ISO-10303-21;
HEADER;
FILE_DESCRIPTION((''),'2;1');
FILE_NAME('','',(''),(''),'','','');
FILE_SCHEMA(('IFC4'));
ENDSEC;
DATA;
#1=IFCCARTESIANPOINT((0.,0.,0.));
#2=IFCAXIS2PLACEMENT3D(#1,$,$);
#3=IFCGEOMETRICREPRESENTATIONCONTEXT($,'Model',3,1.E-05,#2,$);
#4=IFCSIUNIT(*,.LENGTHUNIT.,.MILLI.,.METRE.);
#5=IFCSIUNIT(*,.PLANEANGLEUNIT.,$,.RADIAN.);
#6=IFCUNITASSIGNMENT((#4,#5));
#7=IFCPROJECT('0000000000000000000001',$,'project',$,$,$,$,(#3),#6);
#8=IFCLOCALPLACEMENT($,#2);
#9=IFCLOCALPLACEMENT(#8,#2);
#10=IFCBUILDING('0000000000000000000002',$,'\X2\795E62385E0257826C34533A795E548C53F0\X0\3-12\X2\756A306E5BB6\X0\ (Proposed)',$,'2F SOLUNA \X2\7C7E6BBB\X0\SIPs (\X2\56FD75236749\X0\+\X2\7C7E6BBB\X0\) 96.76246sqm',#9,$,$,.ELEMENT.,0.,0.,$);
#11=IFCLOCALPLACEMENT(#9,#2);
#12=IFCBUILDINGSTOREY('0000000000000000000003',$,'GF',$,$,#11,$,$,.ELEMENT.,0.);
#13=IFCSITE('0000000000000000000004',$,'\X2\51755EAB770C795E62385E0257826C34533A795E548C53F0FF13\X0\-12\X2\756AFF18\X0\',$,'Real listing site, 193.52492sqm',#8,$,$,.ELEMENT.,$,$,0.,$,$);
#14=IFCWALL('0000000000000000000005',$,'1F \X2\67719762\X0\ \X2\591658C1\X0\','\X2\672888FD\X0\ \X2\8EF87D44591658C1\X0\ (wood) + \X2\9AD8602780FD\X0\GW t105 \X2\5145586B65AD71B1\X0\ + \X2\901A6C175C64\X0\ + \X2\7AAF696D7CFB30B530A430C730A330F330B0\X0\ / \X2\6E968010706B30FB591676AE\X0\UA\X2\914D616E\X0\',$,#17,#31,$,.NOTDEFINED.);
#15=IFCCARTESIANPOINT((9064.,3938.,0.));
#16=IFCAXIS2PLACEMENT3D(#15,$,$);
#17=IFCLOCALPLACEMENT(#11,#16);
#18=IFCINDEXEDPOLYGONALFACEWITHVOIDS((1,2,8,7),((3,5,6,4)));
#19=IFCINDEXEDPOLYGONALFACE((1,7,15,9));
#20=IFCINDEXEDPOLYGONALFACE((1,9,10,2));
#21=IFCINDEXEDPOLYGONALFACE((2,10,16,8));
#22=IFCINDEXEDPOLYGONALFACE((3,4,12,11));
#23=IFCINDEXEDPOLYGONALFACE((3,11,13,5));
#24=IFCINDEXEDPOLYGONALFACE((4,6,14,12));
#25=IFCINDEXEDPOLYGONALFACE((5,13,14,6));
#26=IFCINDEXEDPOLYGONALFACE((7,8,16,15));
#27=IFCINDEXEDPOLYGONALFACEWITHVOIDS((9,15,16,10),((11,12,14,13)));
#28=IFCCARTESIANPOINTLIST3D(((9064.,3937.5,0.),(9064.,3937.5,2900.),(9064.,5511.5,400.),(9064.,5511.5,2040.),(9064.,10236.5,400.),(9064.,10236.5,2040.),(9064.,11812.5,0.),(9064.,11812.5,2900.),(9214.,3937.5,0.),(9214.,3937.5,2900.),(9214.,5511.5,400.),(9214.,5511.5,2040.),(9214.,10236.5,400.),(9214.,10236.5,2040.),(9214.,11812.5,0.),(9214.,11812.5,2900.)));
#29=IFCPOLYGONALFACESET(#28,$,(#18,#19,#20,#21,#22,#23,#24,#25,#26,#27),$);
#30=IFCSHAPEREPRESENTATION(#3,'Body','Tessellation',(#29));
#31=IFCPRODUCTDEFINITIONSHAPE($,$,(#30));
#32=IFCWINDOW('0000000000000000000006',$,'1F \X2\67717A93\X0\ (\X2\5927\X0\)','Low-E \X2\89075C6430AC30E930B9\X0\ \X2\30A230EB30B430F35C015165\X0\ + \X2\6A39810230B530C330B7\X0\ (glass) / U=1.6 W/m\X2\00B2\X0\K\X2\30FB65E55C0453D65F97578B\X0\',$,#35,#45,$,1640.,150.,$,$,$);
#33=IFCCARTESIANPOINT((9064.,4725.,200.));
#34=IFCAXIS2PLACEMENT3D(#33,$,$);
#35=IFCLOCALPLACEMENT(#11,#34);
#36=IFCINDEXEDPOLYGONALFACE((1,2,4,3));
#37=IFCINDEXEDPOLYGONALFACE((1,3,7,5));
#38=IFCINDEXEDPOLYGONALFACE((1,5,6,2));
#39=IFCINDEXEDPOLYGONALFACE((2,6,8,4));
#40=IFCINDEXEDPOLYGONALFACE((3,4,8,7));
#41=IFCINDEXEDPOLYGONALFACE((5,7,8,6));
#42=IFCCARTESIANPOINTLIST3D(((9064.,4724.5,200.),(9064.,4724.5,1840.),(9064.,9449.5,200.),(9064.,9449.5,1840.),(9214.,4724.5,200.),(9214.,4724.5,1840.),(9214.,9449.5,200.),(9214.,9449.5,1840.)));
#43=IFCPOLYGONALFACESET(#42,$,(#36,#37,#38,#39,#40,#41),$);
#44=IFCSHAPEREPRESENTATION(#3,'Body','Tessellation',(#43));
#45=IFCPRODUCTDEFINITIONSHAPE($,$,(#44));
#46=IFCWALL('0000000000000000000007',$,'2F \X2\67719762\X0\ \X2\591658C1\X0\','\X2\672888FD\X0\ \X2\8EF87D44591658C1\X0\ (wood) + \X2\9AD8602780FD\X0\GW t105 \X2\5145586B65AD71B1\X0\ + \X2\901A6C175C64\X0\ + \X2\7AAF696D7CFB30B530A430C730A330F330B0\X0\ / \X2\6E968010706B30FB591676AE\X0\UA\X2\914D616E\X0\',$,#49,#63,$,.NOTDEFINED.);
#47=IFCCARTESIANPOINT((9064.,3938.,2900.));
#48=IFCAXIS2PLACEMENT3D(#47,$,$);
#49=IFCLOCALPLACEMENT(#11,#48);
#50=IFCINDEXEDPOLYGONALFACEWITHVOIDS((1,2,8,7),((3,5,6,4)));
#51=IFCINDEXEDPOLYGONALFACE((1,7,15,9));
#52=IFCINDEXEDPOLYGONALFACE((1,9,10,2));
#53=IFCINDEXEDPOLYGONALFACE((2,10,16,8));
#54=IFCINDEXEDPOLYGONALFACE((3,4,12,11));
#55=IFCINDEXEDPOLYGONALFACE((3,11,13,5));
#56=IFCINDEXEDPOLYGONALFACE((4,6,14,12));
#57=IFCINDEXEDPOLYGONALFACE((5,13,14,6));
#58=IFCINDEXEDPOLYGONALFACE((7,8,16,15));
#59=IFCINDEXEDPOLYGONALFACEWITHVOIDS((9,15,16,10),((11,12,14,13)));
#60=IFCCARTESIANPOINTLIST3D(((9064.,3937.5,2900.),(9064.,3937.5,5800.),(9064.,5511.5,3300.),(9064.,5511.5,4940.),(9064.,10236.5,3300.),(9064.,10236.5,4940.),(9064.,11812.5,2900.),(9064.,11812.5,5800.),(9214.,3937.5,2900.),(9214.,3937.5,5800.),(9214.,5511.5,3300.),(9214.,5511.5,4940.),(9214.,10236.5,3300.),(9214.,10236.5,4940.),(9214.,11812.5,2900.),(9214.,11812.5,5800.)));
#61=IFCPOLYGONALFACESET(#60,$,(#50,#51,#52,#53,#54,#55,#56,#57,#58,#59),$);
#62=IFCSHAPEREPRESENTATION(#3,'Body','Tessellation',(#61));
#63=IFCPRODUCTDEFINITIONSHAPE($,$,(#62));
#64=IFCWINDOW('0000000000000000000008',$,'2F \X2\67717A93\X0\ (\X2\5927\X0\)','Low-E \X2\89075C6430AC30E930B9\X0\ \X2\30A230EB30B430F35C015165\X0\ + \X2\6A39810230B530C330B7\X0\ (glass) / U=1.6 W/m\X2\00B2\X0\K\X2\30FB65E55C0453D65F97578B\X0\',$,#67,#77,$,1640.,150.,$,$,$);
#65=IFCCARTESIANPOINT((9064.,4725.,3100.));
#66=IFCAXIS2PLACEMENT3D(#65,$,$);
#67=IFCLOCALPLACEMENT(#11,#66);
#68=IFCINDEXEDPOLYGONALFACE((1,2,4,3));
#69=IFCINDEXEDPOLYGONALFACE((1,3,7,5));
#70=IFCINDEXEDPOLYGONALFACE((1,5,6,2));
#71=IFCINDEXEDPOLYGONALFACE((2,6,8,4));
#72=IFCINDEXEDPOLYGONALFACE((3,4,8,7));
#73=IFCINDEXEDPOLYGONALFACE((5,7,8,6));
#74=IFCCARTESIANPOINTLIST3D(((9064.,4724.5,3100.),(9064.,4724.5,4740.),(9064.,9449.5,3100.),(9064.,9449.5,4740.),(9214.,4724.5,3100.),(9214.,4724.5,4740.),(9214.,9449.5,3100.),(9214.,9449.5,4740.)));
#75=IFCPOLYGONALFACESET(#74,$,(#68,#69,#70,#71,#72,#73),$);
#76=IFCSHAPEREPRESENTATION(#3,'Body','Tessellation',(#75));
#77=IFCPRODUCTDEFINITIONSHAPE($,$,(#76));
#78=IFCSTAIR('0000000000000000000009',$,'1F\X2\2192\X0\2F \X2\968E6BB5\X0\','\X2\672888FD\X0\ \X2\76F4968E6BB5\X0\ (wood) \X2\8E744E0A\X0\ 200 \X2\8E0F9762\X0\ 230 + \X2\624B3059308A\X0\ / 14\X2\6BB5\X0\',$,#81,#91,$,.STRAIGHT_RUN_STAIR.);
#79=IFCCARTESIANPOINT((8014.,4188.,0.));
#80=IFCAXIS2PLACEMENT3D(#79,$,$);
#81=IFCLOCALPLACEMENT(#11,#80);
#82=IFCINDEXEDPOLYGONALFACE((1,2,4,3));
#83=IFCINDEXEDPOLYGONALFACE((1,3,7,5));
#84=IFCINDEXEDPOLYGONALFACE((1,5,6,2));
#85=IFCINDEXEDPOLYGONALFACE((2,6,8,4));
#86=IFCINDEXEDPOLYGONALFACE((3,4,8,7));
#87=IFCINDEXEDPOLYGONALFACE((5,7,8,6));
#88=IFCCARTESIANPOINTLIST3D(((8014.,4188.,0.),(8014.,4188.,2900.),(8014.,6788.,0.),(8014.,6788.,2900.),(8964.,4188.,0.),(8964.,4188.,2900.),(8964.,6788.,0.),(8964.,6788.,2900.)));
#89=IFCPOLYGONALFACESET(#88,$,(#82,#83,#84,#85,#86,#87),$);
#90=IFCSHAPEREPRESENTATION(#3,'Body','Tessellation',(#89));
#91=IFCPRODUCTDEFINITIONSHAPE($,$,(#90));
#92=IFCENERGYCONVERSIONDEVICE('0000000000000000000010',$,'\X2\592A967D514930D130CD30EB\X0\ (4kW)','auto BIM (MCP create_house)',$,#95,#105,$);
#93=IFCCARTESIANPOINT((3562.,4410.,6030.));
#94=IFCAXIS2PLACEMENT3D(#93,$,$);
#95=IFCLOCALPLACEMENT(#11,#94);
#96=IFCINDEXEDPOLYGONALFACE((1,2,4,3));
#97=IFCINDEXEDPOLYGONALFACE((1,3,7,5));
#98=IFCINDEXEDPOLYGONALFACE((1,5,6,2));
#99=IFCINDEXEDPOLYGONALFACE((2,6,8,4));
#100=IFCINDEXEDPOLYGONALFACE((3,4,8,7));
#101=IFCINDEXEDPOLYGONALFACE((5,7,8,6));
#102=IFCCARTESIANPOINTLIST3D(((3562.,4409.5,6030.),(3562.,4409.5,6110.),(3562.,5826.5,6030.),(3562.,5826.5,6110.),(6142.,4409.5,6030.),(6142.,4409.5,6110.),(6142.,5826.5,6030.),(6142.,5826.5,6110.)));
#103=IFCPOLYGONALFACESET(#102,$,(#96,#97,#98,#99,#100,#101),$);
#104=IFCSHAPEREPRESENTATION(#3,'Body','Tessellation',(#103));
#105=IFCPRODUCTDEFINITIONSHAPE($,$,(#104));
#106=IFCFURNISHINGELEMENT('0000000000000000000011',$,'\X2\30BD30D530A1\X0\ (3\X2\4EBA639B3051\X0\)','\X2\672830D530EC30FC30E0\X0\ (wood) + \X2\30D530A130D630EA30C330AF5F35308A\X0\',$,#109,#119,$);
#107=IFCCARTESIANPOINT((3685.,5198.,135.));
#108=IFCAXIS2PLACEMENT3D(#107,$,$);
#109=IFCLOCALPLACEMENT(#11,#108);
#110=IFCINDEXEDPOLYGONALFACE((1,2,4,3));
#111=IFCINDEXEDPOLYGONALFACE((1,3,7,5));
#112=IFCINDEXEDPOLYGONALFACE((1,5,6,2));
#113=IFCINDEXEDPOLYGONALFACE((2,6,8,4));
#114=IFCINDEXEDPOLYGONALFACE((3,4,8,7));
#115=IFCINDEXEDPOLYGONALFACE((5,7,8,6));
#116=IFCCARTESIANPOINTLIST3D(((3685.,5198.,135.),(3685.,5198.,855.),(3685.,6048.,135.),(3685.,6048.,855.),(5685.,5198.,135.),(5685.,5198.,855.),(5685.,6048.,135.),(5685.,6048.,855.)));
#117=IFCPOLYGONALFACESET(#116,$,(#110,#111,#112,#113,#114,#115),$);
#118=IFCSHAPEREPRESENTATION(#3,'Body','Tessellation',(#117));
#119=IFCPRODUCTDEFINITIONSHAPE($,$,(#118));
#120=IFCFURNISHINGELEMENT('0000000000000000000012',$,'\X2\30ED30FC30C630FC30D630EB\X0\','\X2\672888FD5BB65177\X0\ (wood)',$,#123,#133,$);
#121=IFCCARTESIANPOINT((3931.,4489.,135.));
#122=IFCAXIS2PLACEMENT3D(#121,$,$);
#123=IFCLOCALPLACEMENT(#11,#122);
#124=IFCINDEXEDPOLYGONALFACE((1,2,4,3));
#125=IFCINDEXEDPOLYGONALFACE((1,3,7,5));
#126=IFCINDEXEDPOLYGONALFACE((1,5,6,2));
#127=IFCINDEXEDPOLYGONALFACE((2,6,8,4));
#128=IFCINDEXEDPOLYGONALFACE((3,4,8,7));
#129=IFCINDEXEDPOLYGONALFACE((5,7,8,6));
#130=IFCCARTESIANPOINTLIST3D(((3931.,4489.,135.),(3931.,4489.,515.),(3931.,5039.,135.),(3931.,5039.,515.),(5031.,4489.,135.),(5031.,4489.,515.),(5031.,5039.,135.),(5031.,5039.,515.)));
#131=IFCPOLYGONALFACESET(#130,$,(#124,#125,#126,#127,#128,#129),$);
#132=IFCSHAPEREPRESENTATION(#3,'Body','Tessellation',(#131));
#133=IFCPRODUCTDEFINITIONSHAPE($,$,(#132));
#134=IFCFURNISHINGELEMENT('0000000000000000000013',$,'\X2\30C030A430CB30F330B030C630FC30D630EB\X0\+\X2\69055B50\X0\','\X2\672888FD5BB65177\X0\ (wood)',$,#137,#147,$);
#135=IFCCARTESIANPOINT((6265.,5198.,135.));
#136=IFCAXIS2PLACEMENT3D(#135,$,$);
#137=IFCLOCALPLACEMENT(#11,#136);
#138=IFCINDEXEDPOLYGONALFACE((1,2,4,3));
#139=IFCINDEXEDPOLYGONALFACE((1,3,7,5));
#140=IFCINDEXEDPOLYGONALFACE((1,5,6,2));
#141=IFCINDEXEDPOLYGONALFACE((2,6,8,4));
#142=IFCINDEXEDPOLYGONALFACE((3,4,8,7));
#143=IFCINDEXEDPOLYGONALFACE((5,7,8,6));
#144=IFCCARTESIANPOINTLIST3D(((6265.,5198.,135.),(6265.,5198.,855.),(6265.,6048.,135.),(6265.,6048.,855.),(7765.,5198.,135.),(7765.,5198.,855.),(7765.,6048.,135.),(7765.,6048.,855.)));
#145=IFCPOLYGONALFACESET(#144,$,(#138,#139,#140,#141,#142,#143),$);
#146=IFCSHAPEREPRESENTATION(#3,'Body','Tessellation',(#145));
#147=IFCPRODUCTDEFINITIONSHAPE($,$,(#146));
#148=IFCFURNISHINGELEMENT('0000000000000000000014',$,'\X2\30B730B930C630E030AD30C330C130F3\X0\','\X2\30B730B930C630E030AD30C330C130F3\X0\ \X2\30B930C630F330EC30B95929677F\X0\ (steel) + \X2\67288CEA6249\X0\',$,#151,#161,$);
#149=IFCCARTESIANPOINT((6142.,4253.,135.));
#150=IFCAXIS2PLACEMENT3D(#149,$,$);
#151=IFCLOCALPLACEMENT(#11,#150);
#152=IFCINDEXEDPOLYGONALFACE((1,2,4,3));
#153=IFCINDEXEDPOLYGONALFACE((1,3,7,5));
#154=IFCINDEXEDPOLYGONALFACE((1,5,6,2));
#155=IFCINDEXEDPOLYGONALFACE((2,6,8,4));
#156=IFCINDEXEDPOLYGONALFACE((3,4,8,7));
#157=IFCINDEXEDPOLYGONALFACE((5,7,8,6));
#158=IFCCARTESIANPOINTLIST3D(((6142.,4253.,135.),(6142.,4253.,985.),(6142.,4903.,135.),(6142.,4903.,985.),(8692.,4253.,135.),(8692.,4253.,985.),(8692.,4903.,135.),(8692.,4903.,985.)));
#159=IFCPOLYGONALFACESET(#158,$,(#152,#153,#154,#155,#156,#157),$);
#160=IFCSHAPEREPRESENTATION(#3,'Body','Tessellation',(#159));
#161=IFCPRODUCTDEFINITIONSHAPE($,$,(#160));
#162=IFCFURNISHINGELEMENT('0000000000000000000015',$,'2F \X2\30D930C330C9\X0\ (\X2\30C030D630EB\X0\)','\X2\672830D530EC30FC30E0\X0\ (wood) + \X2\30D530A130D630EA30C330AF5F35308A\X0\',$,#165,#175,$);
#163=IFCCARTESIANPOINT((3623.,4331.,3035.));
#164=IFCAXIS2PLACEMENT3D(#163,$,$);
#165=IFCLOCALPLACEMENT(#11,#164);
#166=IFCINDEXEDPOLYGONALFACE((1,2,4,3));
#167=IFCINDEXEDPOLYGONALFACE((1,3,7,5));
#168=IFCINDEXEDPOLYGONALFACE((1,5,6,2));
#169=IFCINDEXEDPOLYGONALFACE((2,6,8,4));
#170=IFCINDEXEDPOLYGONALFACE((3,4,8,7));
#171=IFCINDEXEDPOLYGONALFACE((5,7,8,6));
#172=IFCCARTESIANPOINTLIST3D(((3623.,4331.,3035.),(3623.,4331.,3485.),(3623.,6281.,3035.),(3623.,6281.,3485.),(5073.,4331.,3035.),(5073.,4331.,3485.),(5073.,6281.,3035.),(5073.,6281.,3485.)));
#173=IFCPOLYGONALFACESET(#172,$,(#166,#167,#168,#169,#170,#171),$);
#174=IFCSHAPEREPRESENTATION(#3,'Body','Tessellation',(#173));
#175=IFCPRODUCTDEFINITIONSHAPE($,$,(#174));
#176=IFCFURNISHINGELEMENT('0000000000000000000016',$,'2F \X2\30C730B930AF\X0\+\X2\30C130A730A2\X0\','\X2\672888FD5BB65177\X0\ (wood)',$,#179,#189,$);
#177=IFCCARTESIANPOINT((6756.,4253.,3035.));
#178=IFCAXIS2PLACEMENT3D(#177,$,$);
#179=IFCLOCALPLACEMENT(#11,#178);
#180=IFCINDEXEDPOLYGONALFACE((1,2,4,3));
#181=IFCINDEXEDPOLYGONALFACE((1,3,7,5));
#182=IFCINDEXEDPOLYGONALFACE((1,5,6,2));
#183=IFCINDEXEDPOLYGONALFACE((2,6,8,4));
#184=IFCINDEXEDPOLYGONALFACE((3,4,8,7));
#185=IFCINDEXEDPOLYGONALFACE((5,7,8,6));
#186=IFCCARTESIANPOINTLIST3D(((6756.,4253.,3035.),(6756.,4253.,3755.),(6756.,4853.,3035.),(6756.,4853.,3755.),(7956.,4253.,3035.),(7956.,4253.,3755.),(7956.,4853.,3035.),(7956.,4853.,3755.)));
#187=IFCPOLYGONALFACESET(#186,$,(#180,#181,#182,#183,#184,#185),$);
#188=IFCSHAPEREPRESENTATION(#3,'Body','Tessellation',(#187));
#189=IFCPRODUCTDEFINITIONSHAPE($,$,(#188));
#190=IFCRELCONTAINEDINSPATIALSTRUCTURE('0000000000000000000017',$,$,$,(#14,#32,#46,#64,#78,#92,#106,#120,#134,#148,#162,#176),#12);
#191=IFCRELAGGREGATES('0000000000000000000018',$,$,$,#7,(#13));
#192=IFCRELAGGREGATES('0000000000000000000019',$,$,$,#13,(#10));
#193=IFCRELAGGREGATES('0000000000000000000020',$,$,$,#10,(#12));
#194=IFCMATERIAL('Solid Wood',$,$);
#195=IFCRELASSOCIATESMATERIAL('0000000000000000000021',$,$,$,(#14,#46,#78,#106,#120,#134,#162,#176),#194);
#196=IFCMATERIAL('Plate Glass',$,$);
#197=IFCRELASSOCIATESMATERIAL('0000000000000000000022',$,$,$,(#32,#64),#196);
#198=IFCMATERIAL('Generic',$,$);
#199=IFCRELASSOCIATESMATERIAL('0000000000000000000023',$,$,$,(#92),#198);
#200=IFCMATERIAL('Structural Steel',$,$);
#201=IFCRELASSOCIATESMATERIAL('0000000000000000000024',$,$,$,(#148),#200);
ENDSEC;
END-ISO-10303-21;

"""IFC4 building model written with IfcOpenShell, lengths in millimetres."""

from ifc_helpers import new_model, si_unit, frame, frame_2d, origin, place, context, project, spatial, rectangle, extrude, material, element, fill, save


model = new_model("IFC4")

# Units and contexts
model_context = context("Model", 3, precision=1e-05, world=origin())
ifc_project = project(units=[si_unit("LENGTHUNIT", "METRE", prefix="MILLI"), si_unit("PLANEANGLEUNIT", "RADIAN")], contexts=[model_context])

# Site, building, storey
site_placement = place(None, origin())
site = spatial("IfcSite", under=ifc_project, at=site_placement, Name="兵庫県神戸市垂水区神和台３-12番８", ObjectType="Real listing site, 193.52492sqm", CompositionType="ELEMENT", RefElevation=0.0)
building_placement = place(site_placement, origin())
building = spatial("IfcBuilding", under=site, at=building_placement, Name="神戸市垂水区神和台3-12番の家 (Proposed)", ObjectType="2F SOLUNA 籾殻SIPs (国産杉+籾殻) 96.76246sqm", CompositionType="ELEMENT", ElevationOfRefHeight=0.0, ElevationOfTerrain=0.0)
storey_placement = place(building_placement, origin())
storey = spatial("IfcBuildingStorey", under=building, at=storey_placement, Name="GF", CompositionType="ELEMENT", Elevation=0.0)

# Wall, opening, window
ifc_material_1 = material(Name="Solid Wood")
wall_1_placement = place(storey_placement, frame((9064.0, 3938.0, 0.0)))
wall_1 = element("IfcWall", 1, at=wall_1_placement, inside=storey, material=ifc_material_1, Name="1F 東面 外壁", Description="木製 軸組外壁 (wood) + 高性能GW t105 充填断熱 + 通気層 + 窯業系サイディング / 準耐火・外皮UA配慮", PredefinedType="NOTDEFINED", context=model_context, shape_type="SweptSolid", body=[
    extrude(rectangle(XDim=150.0, YDim=7875.0, at=frame_2d((75.0, 3937.0))), frame((9064.0, 3938.0, 0.0)), (0.0, 0.0, 1.0), 2900.0),
])
opening_1_placement = place(storey_placement, frame((9064.0, 4725.0, 200.0)))
opening_1 = element("IfcOpeningElement", 2, at=opening_1_placement, cuts=wall_1, PredefinedType="NOTDEFINED", context=model_context, shape_type="SweptSolid", body=[
    extrude(rectangle(XDim=150.0, YDim=4725.0, at=frame_2d((75.0, 2362.0))), frame((9064.0, 4725.0, 200.0)), (0.0, 0.0, 1.0), 1640.0),
])
ifc_material_2 = material(Name="Plate Glass")
window_1_placement = place(storey_placement, frame((9064.0, 4725.0, 200.0)))
window_1 = element("IfcWindow", 3, at=window_1_placement, inside=storey, material=ifc_material_2, Name="1F 東窓 (大)", Description="Low-E 複層ガラス アルゴン封入 + 樹脂サッシ (glass) / U=1.6 W/m²K・日射取得型", OverallHeight=1640.0, OverallWidth=150.0, context=model_context, shape_type="SweptSolid", body=[
    extrude(rectangle(XDim=150.0, YDim=4725.0, at=frame_2d((75.0, 2362.0))), frame((9064.0, 4725.0, 200.0)), (0.0, 0.0, 1.0), 1640.0),
])
fill(opening_1, window_1)

# Wall, opening, window
wall_2_placement = place(storey_placement, frame((9064.0, 3938.0, 2900.0)))
wall_2 = element("IfcWall", 4, at=wall_2_placement, inside=storey, material=ifc_material_1, Name="2F 東面 外壁", Description="木製 軸組外壁 (wood) + 高性能GW t105 充填断熱 + 通気層 + 窯業系サイディング / 準耐火・外皮UA配慮", PredefinedType="NOTDEFINED", context=model_context, shape_type="SweptSolid", body=[
    extrude(rectangle(XDim=150.0, YDim=7875.0, at=frame_2d((75.0, 3937.0))), frame((9064.0, 3938.0, 2900.0)), (0.0, 0.0, 1.0), 2900.0),
])
opening_2_placement = place(storey_placement, frame((9064.0, 4725.0, 3100.0)))
opening_2 = element("IfcOpeningElement", 5, at=opening_2_placement, cuts=wall_2, PredefinedType="NOTDEFINED", context=model_context, shape_type="SweptSolid", body=[
    extrude(rectangle(XDim=150.0, YDim=4725.0, at=frame_2d((75.0, 2362.0))), frame((9064.0, 4725.0, 3100.0)), (0.0, 0.0, 1.0), 1640.0),
])
window_2_placement = place(storey_placement, frame((9064.0, 4725.0, 3100.0)))
window_2 = element("IfcWindow", 6, at=window_2_placement, inside=storey, material=ifc_material_2, Name="2F 東窓 (大)", Description="Low-E 複層ガラス アルゴン封入 + 樹脂サッシ (glass) / U=1.6 W/m²K・日射取得型", OverallHeight=1640.0, OverallWidth=150.0, context=model_context, shape_type="SweptSolid", body=[
    extrude(rectangle(XDim=150.0, YDim=4725.0, at=frame_2d((75.0, 2362.0))), frame((9064.0, 4725.0, 3100.0)), (0.0, 0.0, 1.0), 1640.0),
])
fill(opening_2, window_2)

# Stair
stair_placement = place(storey_placement, frame((8014.0, 4188.0, 0.0)))
element("IfcStair", 7, at=stair_placement, inside=storey, material=ifc_material_1, Name="1F→2F 階段", Description="木製 直階段 (wood) 蹴上 200 踏面 230 + 手すり / 14段", PredefinedType="STRAIGHT_RUN_STAIR", context=model_context, shape_type="SweptSolid", body=[
    extrude(rectangle(XDim=950.0, YDim=2600.0, at=frame_2d((475.0, 1300.0))), frame((8014.0, 4188.0, 0.0)), (0.0, 0.0, 1.0), 2900.0),
])

# Energy conversion device
ifc_material_3 = material(Name="Generic")
energy_conversion_device_placement = place(storey_placement, frame((3562.0, 4410.0, 6030.0)))
element("IfcEnergyConversionDevice", 8, at=energy_conversion_device_placement, inside=storey, material=ifc_material_3, Name="太陽光パネル (4kW)", Description="auto BIM (MCP create_house)", context=model_context, shape_type="SweptSolid", body=[
    extrude(rectangle(XDim=2580.0, YDim=1417.0, at=frame_2d((1290.0, 708.0))), frame((3562.0, 4410.0, 6030.0)), (0.0, 0.0, 1.0), 80.0),
])

# Furnishing elements
furnishing_1_placement = place(storey_placement, frame((3685.0, 5198.0, 135.0)))
element("IfcFurnishingElement", 9, at=furnishing_1_placement, inside=storey, material=ifc_material_1, Name="ソファ (3人掛け)", Description="木フレーム (wood) + ファブリック張り", context=model_context, shape_type="SweptSolid", body=[
    extrude(rectangle(XDim=2000.0, YDim=850.0, at=frame_2d((1000.0, 425.0))), frame((3685.0, 5198.0, 135.0)), (0.0, 0.0, 1.0), 720.0),
])
furnishing_2_placement = place(storey_placement, frame((3931.0, 4489.0, 135.0)))
element("IfcFurnishingElement", 10, at=furnishing_2_placement, inside=storey, material=ifc_material_1, Name="ローテーブル", Description="木製家具 (wood)", context=model_context, shape_type="SweptSolid", body=[
    extrude(rectangle(XDim=1100.0, YDim=550.0, at=frame_2d((550.0, 275.0))), frame((3931.0, 4489.0, 135.0)), (0.0, 0.0, 1.0), 380.0),
])
furnishing_3_placement = place(storey_placement, frame((6265.0, 5198.0, 135.0)))
element("IfcFurnishingElement", 11, at=furnishing_3_placement, inside=storey, material=ifc_material_1, Name="ダイニングテーブル+椅子", Description="木製家具 (wood)", context=model_context, shape_type="SweptSolid", body=[
    extrude(rectangle(XDim=1500.0, YDim=850.0, at=frame_2d((750.0, 425.0))), frame((6265.0, 5198.0, 135.0)), (0.0, 0.0, 1.0), 720.0),
])
ifc_material_4 = material(Name="Structural Steel")
furnishing_4_placement = place(storey_placement, frame((6142.0, 4253.0, 135.0)))
element("IfcFurnishingElement", 12, at=furnishing_4_placement, inside=storey, material=ifc_material_4, Name="システムキッチン", Description="システムキッチン ステンレス天板 (steel) + 木質扉", context=model_context, shape_type="SweptSolid", body=[
    extrude(rectangle(XDim=2550.0, YDim=650.0, at=frame_2d((1275.0, 325.0))), frame((6142.0, 4253.0, 135.0)), (0.0, 0.0, 1.0), 850.0),
])
furnishing_5_placement = place(storey_placement, frame((3623.0, 4331.0, 3035.0)))
element("IfcFurnishingElement", 13, at=furnishing_5_placement, inside=storey, material=ifc_material_1, Name="2F ベッド (ダブル)", Description="木フレーム (wood) + ファブリック張り", context=model_context, shape_type="SweptSolid", body=[
    extrude(rectangle(XDim=1450.0, YDim=1950.0, at=frame_2d((725.0, 975.0))), frame((3623.0, 4331.0, 3035.0)), (0.0, 0.0, 1.0), 450.0),
])
furnishing_6_placement = place(storey_placement, frame((6756.0, 4253.0, 3035.0)))
element("IfcFurnishingElement", 14, at=furnishing_6_placement, inside=storey, material=ifc_material_1, Name="2F デスク+チェア", Description="木製家具 (wood)", context=model_context, shape_type="SweptSolid", body=[
    extrude(rectangle(XDim=1200.0, YDim=600.0, at=frame_2d((600.0, 300.0))), frame((6756.0, 4253.0, 3035.0)), (0.0, 0.0, 1.0), 720.0),
])

save(model, "model.ifc")
